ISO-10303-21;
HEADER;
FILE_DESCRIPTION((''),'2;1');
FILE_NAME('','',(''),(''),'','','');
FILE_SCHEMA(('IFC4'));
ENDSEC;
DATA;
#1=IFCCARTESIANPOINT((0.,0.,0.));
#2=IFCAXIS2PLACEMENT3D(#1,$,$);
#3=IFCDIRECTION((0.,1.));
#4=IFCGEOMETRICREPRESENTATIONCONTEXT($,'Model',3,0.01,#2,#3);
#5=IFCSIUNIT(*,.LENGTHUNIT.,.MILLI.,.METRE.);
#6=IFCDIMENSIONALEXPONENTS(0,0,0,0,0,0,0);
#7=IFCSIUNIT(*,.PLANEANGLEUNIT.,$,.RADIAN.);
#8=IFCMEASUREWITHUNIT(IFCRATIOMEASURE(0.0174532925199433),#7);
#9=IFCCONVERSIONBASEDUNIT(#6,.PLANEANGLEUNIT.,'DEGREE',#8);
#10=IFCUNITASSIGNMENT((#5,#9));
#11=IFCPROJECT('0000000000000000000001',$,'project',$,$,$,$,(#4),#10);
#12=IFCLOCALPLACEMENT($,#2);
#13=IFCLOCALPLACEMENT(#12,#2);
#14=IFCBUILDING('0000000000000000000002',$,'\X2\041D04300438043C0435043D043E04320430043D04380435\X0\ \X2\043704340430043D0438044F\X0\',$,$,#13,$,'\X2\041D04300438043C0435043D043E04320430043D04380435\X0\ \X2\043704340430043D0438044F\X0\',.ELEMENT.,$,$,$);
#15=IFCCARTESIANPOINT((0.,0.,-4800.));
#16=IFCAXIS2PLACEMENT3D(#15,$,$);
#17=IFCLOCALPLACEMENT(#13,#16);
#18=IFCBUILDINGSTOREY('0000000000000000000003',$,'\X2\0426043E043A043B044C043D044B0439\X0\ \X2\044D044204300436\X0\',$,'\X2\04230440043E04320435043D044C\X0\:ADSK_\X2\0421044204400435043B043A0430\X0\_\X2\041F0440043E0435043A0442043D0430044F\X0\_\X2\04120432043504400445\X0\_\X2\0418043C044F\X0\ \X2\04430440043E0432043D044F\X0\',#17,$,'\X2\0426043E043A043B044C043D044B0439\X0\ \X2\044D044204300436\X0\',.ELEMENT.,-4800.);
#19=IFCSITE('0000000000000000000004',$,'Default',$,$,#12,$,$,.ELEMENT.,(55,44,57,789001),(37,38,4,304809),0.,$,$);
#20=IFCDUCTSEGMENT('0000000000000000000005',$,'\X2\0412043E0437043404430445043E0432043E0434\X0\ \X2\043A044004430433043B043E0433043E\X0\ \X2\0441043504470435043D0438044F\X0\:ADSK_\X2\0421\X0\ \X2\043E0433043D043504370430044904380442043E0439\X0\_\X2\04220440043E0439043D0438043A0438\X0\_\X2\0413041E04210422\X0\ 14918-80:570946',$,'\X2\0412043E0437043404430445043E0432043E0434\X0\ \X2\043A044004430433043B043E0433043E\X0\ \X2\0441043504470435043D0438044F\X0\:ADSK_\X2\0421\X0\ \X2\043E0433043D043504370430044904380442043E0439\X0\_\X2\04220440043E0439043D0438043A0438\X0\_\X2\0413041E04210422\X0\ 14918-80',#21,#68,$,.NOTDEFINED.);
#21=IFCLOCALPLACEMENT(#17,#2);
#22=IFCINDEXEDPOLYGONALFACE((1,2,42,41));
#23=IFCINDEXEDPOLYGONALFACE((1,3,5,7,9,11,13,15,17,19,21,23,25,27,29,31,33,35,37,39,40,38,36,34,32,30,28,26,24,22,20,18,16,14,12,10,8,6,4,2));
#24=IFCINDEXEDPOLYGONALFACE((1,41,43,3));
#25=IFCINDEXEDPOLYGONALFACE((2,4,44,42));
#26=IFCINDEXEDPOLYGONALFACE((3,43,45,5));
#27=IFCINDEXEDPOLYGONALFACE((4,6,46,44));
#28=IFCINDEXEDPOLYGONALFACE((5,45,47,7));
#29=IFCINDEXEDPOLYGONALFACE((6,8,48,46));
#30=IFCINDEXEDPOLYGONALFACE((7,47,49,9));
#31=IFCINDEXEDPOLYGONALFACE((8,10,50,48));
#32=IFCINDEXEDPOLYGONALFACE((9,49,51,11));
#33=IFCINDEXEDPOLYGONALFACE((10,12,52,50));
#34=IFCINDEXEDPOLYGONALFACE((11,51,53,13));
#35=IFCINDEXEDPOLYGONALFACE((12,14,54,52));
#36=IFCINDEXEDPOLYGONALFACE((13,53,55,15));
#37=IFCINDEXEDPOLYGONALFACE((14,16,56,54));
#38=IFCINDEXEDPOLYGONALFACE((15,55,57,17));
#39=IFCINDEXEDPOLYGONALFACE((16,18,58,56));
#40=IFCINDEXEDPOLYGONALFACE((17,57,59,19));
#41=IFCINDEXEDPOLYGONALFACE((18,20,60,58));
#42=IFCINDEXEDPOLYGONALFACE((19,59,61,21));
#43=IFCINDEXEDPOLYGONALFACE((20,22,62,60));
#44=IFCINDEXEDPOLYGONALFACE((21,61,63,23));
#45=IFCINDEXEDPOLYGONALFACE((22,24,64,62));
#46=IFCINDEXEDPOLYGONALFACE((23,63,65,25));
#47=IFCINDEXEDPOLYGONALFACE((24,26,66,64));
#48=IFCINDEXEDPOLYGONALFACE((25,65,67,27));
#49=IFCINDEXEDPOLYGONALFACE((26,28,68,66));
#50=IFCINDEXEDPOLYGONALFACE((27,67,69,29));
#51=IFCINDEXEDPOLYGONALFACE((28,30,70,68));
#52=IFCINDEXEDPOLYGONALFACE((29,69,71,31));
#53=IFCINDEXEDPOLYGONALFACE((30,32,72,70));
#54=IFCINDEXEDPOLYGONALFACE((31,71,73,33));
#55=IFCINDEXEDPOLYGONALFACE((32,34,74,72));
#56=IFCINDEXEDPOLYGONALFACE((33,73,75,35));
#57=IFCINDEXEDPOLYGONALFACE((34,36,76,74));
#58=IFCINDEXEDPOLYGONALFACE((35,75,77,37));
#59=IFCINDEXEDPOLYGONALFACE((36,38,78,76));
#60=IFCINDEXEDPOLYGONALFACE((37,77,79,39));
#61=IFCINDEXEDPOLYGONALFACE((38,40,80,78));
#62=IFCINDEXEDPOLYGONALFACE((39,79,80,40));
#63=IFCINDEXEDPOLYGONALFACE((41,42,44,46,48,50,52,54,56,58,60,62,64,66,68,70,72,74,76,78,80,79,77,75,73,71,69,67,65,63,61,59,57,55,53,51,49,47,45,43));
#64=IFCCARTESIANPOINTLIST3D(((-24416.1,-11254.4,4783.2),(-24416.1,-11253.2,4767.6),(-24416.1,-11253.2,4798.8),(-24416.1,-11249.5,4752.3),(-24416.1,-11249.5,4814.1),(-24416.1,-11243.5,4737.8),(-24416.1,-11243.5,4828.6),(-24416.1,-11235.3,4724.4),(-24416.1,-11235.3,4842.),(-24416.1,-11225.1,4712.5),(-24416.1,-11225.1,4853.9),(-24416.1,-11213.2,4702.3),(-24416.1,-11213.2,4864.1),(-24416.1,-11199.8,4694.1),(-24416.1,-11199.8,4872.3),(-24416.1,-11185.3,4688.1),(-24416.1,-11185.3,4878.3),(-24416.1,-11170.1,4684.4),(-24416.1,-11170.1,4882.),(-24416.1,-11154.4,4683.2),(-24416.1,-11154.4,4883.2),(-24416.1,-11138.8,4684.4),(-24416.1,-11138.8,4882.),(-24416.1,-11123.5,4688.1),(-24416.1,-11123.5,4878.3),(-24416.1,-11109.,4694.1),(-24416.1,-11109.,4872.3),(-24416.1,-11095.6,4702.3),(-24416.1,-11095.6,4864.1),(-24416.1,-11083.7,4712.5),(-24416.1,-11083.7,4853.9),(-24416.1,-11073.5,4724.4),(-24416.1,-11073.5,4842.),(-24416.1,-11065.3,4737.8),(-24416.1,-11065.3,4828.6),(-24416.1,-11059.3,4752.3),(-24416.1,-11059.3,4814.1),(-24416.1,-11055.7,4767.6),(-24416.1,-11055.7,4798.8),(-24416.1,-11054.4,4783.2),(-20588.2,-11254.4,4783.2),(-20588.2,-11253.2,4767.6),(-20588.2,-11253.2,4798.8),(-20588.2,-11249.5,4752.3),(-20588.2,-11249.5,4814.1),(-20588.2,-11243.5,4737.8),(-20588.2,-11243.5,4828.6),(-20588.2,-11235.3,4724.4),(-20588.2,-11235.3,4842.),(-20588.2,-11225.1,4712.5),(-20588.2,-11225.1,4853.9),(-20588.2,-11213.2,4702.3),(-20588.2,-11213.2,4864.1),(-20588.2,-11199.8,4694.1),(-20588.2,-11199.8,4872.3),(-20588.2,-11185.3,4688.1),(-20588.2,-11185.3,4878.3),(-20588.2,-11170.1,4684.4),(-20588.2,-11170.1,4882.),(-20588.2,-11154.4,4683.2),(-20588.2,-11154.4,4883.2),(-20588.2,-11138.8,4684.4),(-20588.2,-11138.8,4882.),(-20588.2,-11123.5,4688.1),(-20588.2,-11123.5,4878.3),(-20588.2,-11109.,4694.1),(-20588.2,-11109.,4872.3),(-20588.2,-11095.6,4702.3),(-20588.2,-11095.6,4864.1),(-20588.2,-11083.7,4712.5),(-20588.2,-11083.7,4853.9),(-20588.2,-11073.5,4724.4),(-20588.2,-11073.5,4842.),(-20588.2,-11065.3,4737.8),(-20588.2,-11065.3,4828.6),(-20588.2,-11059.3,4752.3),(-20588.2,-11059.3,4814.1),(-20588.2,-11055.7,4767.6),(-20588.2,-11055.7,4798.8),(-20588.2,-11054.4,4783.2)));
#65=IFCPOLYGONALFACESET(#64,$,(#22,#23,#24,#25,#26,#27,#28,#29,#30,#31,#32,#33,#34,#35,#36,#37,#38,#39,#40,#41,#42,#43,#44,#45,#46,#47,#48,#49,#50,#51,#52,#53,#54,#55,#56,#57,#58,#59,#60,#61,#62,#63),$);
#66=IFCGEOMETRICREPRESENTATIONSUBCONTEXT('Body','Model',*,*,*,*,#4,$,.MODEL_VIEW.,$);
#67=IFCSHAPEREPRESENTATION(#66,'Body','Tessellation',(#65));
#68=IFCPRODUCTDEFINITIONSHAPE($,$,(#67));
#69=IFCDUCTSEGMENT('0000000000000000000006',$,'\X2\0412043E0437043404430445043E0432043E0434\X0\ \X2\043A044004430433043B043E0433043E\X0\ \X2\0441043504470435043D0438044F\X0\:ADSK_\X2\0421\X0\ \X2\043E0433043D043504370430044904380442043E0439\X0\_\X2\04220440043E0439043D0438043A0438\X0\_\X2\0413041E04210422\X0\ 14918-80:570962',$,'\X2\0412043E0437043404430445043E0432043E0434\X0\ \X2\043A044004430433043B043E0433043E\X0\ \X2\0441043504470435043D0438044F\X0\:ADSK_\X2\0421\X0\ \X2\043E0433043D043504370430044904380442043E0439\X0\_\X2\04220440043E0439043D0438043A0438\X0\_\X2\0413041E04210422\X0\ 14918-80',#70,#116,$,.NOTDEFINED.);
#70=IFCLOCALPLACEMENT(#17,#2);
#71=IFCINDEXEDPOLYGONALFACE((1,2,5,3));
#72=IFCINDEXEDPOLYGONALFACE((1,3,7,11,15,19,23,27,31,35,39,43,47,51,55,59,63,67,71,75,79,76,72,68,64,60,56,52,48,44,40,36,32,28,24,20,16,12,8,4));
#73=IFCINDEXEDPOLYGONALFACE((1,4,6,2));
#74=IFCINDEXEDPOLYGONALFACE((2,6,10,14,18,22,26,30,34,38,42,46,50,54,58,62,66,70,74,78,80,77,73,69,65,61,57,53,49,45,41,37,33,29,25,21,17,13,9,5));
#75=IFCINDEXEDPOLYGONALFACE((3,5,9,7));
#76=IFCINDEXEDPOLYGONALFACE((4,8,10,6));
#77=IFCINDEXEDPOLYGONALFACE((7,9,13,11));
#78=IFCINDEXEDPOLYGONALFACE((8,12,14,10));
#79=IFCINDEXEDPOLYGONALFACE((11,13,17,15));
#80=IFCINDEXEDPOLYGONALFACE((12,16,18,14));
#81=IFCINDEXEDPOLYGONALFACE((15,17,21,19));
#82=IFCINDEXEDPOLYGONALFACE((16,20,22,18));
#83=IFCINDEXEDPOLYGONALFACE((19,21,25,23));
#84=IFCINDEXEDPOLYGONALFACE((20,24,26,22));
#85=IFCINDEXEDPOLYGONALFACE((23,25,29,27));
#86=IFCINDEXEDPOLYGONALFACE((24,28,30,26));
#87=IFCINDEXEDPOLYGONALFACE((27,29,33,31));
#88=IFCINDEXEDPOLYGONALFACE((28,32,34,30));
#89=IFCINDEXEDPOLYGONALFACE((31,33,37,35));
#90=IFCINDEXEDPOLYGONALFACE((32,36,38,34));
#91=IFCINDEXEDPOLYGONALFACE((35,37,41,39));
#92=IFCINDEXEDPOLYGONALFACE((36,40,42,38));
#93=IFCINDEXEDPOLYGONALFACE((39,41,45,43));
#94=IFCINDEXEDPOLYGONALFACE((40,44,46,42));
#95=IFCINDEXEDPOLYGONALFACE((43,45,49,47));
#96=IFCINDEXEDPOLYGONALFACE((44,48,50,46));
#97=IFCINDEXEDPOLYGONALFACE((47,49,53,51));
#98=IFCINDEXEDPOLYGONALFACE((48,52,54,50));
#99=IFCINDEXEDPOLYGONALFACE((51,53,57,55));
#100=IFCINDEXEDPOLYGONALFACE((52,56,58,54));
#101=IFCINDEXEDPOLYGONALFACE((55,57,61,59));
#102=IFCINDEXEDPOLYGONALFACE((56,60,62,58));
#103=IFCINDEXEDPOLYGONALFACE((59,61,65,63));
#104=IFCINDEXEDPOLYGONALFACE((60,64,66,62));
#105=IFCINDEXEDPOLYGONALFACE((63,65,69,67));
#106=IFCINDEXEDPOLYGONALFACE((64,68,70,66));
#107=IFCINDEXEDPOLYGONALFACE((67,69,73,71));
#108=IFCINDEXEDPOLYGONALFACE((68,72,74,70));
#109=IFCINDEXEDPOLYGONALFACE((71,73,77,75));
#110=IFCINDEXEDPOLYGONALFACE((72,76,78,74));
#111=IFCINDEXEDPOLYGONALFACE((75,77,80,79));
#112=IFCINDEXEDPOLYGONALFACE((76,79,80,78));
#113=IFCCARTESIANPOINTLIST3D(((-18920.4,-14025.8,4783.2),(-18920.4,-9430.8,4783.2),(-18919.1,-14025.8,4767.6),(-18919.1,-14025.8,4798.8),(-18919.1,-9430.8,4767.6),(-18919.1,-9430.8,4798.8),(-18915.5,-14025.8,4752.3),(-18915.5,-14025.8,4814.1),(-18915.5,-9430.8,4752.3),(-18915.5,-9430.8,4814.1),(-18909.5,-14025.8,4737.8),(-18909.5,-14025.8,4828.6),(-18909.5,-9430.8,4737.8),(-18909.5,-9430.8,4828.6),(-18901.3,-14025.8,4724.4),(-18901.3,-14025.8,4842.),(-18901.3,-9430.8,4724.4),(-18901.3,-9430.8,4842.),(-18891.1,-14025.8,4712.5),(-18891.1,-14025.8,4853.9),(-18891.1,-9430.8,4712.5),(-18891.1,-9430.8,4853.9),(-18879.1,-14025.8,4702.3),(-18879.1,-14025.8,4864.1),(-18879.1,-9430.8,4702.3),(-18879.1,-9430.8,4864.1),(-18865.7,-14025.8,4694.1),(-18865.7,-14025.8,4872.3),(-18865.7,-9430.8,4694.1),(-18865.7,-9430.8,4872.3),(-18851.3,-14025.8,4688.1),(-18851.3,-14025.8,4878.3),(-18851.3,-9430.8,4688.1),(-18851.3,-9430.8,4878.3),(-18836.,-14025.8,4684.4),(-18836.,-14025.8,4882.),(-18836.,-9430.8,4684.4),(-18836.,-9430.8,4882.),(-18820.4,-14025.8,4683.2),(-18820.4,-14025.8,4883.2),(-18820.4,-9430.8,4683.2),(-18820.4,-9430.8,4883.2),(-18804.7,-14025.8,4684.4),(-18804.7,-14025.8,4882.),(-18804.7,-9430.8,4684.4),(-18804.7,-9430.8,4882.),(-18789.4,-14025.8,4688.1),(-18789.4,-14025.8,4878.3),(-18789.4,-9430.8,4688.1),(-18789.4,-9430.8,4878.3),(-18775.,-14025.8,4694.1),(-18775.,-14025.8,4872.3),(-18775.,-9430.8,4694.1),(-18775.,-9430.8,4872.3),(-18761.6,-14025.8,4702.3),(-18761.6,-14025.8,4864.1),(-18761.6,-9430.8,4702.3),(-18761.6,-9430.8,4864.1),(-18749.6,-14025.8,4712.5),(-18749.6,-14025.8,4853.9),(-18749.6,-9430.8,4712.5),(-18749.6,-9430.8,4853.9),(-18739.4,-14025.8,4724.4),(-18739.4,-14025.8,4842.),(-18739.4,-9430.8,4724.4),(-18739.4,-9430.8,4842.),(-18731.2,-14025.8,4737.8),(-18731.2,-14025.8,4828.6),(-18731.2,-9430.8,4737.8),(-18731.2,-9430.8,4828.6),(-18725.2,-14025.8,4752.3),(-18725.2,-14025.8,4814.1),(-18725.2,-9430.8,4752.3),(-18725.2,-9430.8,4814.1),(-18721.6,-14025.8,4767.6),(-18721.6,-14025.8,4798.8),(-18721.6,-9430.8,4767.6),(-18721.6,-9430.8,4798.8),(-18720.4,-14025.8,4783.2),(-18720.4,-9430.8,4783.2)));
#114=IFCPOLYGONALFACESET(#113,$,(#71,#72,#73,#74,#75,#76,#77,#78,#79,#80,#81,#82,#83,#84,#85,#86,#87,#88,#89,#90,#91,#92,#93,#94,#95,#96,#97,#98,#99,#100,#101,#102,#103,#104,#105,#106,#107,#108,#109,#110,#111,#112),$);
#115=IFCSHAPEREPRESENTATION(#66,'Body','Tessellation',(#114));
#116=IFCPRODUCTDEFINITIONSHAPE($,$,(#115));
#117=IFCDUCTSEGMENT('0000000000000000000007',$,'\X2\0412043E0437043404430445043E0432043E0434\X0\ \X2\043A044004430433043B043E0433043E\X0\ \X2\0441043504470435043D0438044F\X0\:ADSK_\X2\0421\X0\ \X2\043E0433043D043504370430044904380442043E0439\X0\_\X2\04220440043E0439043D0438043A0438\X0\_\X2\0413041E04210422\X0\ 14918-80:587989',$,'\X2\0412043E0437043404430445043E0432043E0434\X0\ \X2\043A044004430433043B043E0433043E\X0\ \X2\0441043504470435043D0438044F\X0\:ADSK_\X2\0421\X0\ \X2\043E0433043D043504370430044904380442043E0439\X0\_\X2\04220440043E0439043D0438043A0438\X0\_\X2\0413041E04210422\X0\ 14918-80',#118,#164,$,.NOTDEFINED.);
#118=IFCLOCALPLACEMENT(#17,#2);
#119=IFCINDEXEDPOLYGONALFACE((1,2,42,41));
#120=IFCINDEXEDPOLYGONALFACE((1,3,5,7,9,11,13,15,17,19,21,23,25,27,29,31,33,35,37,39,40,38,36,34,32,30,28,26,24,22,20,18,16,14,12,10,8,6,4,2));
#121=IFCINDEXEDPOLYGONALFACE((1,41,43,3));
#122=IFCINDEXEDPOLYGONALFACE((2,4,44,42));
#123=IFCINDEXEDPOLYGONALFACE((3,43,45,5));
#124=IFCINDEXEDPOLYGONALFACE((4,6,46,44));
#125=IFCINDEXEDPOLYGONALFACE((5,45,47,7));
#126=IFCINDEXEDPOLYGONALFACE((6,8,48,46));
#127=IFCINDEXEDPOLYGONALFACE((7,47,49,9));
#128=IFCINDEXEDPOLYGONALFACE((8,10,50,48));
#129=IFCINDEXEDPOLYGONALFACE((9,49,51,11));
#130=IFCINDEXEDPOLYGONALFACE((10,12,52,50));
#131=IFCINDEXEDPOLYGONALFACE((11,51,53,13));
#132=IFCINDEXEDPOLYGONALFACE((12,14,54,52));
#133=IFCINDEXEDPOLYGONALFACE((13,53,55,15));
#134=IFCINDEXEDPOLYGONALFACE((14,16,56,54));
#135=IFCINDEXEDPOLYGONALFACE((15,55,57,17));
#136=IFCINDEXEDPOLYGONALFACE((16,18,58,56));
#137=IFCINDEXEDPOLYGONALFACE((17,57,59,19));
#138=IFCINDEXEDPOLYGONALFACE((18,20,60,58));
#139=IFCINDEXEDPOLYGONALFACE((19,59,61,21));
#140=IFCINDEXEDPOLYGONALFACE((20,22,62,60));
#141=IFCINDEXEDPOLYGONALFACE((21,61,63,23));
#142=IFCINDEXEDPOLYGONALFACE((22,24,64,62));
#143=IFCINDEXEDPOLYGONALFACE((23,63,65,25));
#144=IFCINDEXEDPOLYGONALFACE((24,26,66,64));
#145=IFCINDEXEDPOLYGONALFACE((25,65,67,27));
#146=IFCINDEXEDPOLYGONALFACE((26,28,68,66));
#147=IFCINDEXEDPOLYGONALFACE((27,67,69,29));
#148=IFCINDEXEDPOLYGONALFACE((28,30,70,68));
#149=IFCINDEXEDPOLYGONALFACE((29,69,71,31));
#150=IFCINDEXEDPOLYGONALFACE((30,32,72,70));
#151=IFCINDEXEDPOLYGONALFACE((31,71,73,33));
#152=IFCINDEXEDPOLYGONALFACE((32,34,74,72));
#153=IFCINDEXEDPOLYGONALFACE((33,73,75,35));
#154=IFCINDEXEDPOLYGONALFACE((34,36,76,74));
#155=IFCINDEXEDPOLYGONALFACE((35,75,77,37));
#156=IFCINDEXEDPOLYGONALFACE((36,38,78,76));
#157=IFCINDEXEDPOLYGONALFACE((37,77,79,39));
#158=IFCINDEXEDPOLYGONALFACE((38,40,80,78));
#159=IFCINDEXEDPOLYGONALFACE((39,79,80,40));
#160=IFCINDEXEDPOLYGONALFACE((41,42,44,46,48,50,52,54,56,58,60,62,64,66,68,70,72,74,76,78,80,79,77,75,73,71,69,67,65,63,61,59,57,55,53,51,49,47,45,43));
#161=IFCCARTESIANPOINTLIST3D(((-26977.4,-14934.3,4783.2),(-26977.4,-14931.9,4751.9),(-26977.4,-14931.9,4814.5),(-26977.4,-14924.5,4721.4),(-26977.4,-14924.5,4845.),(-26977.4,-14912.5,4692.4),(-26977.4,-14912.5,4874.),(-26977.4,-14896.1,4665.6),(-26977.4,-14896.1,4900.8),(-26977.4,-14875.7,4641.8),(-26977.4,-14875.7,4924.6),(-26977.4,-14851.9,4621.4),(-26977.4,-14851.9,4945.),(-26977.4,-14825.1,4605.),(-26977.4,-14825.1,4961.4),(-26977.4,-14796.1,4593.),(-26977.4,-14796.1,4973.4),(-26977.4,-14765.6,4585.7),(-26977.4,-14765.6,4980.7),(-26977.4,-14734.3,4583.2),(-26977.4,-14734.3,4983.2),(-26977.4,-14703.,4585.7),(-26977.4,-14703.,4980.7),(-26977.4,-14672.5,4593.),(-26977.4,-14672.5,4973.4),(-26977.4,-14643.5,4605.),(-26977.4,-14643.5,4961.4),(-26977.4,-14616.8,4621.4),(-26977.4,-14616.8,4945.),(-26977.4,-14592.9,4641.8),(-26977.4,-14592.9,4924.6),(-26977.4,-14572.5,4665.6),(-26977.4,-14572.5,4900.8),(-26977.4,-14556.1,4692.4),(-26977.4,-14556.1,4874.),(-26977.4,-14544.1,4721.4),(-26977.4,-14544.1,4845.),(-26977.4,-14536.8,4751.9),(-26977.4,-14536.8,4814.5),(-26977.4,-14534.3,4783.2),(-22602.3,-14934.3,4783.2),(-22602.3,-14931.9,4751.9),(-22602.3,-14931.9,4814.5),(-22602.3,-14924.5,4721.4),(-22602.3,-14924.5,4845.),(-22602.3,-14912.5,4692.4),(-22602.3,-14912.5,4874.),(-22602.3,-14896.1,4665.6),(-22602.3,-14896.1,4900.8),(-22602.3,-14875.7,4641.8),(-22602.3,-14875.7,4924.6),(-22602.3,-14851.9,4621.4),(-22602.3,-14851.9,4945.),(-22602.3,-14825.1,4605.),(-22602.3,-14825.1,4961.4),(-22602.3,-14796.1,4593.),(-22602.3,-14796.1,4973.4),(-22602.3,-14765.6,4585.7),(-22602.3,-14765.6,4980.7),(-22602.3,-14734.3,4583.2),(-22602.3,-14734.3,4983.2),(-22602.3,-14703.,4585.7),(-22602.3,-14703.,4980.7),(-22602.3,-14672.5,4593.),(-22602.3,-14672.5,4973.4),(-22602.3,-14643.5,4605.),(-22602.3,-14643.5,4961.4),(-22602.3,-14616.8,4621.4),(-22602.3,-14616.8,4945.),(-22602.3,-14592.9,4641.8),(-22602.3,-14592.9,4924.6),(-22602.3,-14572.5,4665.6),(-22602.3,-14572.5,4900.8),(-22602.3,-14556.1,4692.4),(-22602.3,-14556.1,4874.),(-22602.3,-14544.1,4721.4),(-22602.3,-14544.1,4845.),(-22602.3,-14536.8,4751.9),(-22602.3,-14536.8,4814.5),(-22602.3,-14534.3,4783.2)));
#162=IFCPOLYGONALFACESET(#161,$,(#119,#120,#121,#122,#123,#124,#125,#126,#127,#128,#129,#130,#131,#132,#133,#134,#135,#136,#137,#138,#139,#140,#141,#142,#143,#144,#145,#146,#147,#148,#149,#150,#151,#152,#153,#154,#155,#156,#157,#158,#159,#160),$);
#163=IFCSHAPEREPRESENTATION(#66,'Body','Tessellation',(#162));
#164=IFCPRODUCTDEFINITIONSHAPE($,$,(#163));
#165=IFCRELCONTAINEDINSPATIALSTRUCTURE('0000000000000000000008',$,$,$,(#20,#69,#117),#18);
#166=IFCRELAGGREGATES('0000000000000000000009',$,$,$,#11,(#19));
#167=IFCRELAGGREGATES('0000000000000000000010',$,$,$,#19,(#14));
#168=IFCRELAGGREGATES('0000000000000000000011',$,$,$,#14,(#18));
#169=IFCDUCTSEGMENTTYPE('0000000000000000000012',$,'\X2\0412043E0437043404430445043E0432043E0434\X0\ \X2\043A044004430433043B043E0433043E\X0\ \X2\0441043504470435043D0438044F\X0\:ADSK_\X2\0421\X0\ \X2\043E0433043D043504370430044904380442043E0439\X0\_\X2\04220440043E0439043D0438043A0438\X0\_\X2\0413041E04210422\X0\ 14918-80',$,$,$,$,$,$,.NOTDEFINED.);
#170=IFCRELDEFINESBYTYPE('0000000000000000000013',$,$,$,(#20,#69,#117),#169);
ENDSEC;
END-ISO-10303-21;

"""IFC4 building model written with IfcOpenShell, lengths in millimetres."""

from ifc_helpers import new_model, entity, si_unit, converted_unit, direction, frame, origin, place, context, subcontext, project, spatial, indexed_curve, outline, extrude, type_object, element, save


model = new_model("IFC4")

# Units and contexts
model_context = context("Model", 3, precision=0.01, world=origin(), true_north=direction((0.0, 1.0)))
body_context = subcontext(model_context, "Body", "Model", "MODEL_VIEW")
ifc_project = project(units=[si_unit("LENGTHUNIT", "METRE", prefix="MILLI"), converted_unit("PLANEANGLEUNIT", "DEGREE", entity("IfcRatioMeasure", 0.0174532925199433), si_unit("PLANEANGLEUNIT", "RADIAN"), dimensions=[0, 0, 0, 0, 0, 0, 0])], contexts=[model_context])

# Site, building, storey
site_placement = place(None, origin())
site = spatial("IfcSite", under=ifc_project, at=site_placement, Name="Default", CompositionType="ELEMENT", RefLatitude=(55, 44, 57, 789001), RefLongitude=(37, 38, 4, 304809), RefElevation=0.0)
building_placement = place(site_placement, origin())
building = spatial("IfcBuilding", under=site, at=building_placement, Name="Наименование здания", LongName="Наименование здания", CompositionType="ELEMENT")
storey_placement = place(building_placement, frame((0.0, 0.0, -4800.0)))
storey = spatial("IfcBuildingStorey", under=building, at=storey_placement, Name="Цокльный этаж", ObjectType="Уровень:ADSK_Стрелка_Проектная_Вверх_Имя уровня", LongName="Цокльный этаж", CompositionType="ELEMENT", Elevation=-4800.0)

# Duct segments
duct_segment_type = type_object("IfcDuctSegmentType", Name="Воздуховод круглого сечения:ADSK_С огнезащитой_Тройники_ГОСТ 14918-80", PredefinedType="NOTDEFINED")
duct_segment_1_placement = place(storey_placement, origin())
element("IfcDuctSegment", 1, at=duct_segment_1_placement, inside=storey, type_object=duct_segment_type, Name="Воздуховод круглого сечения:ADSK_С огнезащитой_Тройники_ГОСТ 14918-80:570946", ObjectType="Воздуховод круглого сечения:ADSK_С огнезащитой_Тройники_ГОСТ 14918-80", PredefinedType="NOTDEFINED", context=body_context, shape_type="SweptSolid", body=[
    extrude(outline(indexed_curve([(100.0, 0.0), (98.8, 15.6), (95.1, 30.9), (89.1, 45.4), (80.9, 58.8), (70.7, 70.7), (58.8, 80.9), (45.4, 89.1), (30.9, 95.1), (15.6, 98.8), (0.0, 100.0), (-15.6, 98.8), (-30.9, 95.1), (-45.4, 89.1), (-58.8, 80.9), (-70.7, 70.7), (-80.9, 58.8), (-89.1, 45.4), (-95.1, 30.9), (-98.8, 15.6), (-100.0, 0.0), (-98.8, -15.6), (-95.1, -30.9), (-89.1, -45.4), (-80.9, -58.8), (-70.7, -70.7), (-58.8, -80.9), (-45.4, -89.1), (-30.9, -95.1), (-15.6, -98.8), (0.0, -100.0), (15.6, -98.8), (30.9, -95.1), (45.4, -89.1), (58.8, -80.9), (70.7, -70.7), (80.9, -58.8), (89.1, -45.4), (95.1, -30.9), (98.8, -15.6), (100.0, 0.0)], self_intersect=False)), frame((-24416.1, -11154.4, 4783.2), z_axis=(1.0, 0.0, 0.0), x_axis=(0.0, -1.0, 0.0)), (0.0, 0.0, 1.0), 3827.9),
])
duct_segment_2_placement = place(storey_placement, origin())
element("IfcDuctSegment", 2, at=duct_segment_2_placement, inside=storey, type_object=duct_segment_type, Name="Воздуховод круглого сечения:ADSK_С огнезащитой_Тройники_ГОСТ 14918-80:570962", ObjectType="Воздуховод круглого сечения:ADSK_С огнезащитой_Тройники_ГОСТ 14918-80", PredefinedType="NOTDEFINED", context=body_context, shape_type="SweptSolid", body=[
    extrude(outline(indexed_curve([(100.0, 0.0), (98.8, 15.6), (95.1, 30.9), (89.1, 45.4), (80.9, 58.8), (70.7, 70.7), (58.8, 80.9), (45.4, 89.1), (30.9, 95.1), (15.6, 98.8), (0.0, 100.0), (-15.6, 98.8), (-30.9, 95.1), (-45.4, 89.1), (-58.8, 80.9), (-70.7, 70.7), (-80.9, 58.8), (-89.1, 45.4), (-95.1, 30.9), (-98.8, 15.6), (-100.0, 0.0), (-98.8, -15.6), (-95.1, -30.9), (-89.1, -45.4), (-80.9, -58.8), (-70.7, -70.7), (-58.8, -80.9), (-45.4, -89.1), (-30.9, -95.1), (-15.6, -98.8), (0.0, -100.0), (15.6, -98.8), (30.9, -95.1), (45.4, -89.1), (58.8, -80.9), (70.7, -70.7), (80.9, -58.8), (89.1, -45.4), (95.1, -30.9), (98.8, -15.6), (100.0, 0.0)], self_intersect=False)), frame((-18820.4, -14025.8, 4783.2), z_axis=(0.0, 1.0, 0.0), x_axis=(-1.0, 0.0, 0.0)), (0.0, 0.0, 1.0), 4595.0),
])
duct_segment_3_placement = place(storey_placement, origin())
element("IfcDuctSegment", 3, at=duct_segment_3_placement, inside=storey, type_object=duct_segment_type, Name="Воздуховод круглого сечения:ADSK_С огнезащитой_Тройники_ГОСТ 14918-80:587989", ObjectType="Воздуховод круглого сечения:ADSK_С огнезащитой_Тройники_ГОСТ 14918-80", PredefinedType="NOTDEFINED", context=body_context, shape_type="SweptSolid", body=[
    extrude(outline(indexed_curve([(200.0, 0.0), (197.5, 31.3), (190.2, 61.8), (178.2, 90.8), (161.8, 117.6), (141.4, 141.4), (117.6, 161.8), (90.8, 178.2), (61.8, 190.2), (31.3, 197.5), (0.0, 200.0), (-31.3, 197.5), (-61.8, 190.2), (-90.8, 178.2), (-117.6, 161.8), (-141.4, 141.4), (-161.8, 117.6), (-178.2, 90.8), (-190.2, 61.8), (-197.5, 31.3), (-200.0, 0.0), (-197.5, -31.3), (-190.2, -61.8), (-178.2, -90.8), (-161.8, -117.6), (-141.4, -141.4), (-117.6, -161.8), (-90.8, -178.2), (-61.8, -190.2), (-31.3, -197.5), (0.0, -200.0), (31.3, -197.5), (61.8, -190.2), (90.8, -178.2), (117.6, -161.8), (141.4, -141.4), (161.8, -117.6), (178.2, -90.8), (190.2, -61.8), (197.5, -31.3), (200.0, 0.0)], self_intersect=False)), frame((-26977.4, -14734.3, 4783.2), z_axis=(1.0, 0.0, 0.0), x_axis=(0.0, -1.0, 0.0)), (0.0, 0.0, 1.0), 4375.1),
])

save(model, "model.ifc")
